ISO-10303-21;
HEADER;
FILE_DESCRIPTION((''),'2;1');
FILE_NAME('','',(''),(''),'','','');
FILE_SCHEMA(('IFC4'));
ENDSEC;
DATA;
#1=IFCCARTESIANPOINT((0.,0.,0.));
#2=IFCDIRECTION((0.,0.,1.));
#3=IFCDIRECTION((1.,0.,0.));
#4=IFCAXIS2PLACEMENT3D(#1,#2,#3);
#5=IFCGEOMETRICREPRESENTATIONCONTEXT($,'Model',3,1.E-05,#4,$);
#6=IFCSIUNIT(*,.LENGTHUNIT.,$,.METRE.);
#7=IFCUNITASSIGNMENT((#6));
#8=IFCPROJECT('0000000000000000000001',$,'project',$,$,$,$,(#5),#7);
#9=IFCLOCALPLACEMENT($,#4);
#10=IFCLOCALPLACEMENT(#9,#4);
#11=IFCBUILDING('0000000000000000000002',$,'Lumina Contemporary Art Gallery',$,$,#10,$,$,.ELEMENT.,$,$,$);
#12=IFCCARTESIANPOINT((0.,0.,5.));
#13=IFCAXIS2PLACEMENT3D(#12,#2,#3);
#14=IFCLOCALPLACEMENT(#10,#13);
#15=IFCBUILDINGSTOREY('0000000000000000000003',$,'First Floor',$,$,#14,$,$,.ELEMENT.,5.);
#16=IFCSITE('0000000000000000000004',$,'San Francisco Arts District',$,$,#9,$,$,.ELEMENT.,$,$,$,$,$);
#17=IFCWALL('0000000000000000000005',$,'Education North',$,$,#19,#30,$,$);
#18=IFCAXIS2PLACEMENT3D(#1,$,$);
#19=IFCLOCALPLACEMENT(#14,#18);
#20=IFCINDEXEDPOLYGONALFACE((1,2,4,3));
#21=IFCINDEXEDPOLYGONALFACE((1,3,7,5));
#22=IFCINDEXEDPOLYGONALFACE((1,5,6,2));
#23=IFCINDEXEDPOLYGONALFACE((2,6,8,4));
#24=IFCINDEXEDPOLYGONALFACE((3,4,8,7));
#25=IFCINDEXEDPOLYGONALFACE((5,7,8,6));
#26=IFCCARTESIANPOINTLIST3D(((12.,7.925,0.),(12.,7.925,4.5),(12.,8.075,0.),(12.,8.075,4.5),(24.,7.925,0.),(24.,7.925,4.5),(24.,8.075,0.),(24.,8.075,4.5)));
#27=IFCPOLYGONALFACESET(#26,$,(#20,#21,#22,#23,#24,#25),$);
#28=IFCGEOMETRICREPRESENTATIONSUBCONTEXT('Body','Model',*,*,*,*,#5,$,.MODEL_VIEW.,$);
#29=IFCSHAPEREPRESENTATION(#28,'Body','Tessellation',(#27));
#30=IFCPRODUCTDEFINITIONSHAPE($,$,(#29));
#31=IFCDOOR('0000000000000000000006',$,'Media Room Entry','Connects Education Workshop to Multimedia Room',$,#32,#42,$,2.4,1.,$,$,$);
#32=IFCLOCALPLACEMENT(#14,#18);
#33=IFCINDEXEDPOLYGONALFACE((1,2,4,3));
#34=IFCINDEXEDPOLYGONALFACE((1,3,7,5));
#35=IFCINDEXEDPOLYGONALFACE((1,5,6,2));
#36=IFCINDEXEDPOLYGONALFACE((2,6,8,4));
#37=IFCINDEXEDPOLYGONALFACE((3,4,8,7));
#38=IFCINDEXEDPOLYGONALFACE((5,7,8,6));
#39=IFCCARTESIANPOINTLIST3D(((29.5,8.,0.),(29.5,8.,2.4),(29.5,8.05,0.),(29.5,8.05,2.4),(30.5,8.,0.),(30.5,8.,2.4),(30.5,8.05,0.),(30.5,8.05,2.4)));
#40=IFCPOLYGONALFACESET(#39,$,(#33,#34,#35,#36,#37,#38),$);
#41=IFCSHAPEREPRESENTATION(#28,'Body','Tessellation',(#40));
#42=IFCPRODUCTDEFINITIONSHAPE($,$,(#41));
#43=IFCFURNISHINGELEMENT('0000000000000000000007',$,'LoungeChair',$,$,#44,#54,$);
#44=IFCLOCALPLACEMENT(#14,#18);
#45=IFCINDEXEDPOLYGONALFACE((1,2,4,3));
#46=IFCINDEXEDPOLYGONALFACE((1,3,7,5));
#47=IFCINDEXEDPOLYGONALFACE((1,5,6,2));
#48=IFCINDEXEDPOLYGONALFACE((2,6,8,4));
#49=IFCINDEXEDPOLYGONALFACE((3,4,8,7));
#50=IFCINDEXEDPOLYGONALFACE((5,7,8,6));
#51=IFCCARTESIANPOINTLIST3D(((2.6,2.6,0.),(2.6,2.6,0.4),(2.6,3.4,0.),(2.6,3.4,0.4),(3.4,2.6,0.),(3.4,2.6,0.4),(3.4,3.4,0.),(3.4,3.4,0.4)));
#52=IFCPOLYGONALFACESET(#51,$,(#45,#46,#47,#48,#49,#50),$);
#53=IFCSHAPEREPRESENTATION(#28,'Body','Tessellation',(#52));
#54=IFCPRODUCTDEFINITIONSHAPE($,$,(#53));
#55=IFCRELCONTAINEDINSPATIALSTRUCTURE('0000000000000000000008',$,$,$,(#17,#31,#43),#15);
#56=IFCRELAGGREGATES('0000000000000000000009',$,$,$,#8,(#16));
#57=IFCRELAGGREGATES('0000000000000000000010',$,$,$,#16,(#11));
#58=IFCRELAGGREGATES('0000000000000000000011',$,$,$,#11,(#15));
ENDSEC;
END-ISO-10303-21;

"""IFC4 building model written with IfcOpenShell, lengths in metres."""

from ifc_helpers import new_model, si_unit, frame, origin_with_axes, place, context, subcontext, project, spatial, polyline, outline, extrude, element, fill, save


model = new_model("IFC4")

# Units and contexts
model_context = context("Model", 3, precision=1e-05, world=origin_with_axes())
body_context = subcontext(model_context, "Body", "Model", "MODEL_VIEW")
ifc_project = project(units=[si_unit("LENGTHUNIT", "METRE")], contexts=[model_context])

# Site, building, storey
site_placement = place(None, origin_with_axes())
site = spatial("IfcSite", under=ifc_project, at=site_placement, Name="San Francisco Arts District", CompositionType="ELEMENT")
building_placement = place(site_placement, origin_with_axes())
building = spatial("IfcBuilding", under=site, at=building_placement, Name="Lumina Contemporary Art Gallery", CompositionType="ELEMENT")
storey_placement = place(building_placement, frame((0.0, 0.0, 5.0), z_axis=(0.0, 0.0, 1.0), x_axis=(1.0, 0.0, 0.0)))
storey = spatial("IfcBuildingStorey", under=building, at=storey_placement, Name="First Floor", CompositionType="ELEMENT", Elevation=5.0)

# Wall, opening, door
wall_1_placement = place(storey_placement, origin_with_axes())
wall_1 = element("IfcWall", 1, at=wall_1_placement, inside=storey, Name="Education North", context=body_context, shape_type="SweptSolid", body=[
    extrude(outline(polyline([(12.0, 7.925, 0.0), (24.0, 7.925, 0.0), (24.0, 8.075, 0.0), (12.0, 8.075, 0.0), (12.0, 7.925, 0.0)])), None, (0.0, 0.0, 1.0), 4.5),
])
opening_1_placement = place(storey_placement, origin_with_axes())
opening_1 = element("IfcOpeningElement", 2, at=opening_1_placement, inside=storey, cuts=wall_1, context=body_context, shape_type="SweptSolid", body=[
    extrude(outline(polyline([(29.5, 7.85, 0.0), (30.5, 7.85, 0.0), (30.5, 8.15, 0.0), (29.5, 8.15, 0.0), (29.5, 7.85, 0.0)])), None, (0.0, 0.0, 1.0), 2.4),
])
door_1_placement = place(storey_placement, origin_with_axes())
door_1 = element("IfcDoor", 3, at=door_1_placement, inside=storey, Name="Media Room Entry", Description="Connects Education Workshop to Multimedia Room", OverallHeight=2.4, OverallWidth=1.0, context=body_context, shape_type="SweptSolid", body=[
    extrude(outline(polyline([(29.5, 8.0, 0.0), (30.5, 8.0, 0.0), (30.5, 8.05, 0.0), (29.5, 8.05, 0.0), (29.5, 8.0, 0.0)])), None, (0.0, 0.0, 1.0), 2.4),
])
fill(opening_1, door_1)

# Furnishing element
furnishing_placement = place(storey_placement, origin_with_axes())
element("IfcFurnishingElement", 4, at=furnishing_placement, inside=storey, Name="LoungeChair", context=body_context, shape_type="SweptSolid", body=[
    extrude(outline(polyline([(2.6, 3.4, 0.0), (2.6, 2.6, 0.0), (3.4, 2.6, 0.0), (3.4, 3.4, 0.0), (2.6, 3.4, 0.0)])), None, (0.0, 0.0, 1.0), 0.4),
])

save(model, "model.ifc")
